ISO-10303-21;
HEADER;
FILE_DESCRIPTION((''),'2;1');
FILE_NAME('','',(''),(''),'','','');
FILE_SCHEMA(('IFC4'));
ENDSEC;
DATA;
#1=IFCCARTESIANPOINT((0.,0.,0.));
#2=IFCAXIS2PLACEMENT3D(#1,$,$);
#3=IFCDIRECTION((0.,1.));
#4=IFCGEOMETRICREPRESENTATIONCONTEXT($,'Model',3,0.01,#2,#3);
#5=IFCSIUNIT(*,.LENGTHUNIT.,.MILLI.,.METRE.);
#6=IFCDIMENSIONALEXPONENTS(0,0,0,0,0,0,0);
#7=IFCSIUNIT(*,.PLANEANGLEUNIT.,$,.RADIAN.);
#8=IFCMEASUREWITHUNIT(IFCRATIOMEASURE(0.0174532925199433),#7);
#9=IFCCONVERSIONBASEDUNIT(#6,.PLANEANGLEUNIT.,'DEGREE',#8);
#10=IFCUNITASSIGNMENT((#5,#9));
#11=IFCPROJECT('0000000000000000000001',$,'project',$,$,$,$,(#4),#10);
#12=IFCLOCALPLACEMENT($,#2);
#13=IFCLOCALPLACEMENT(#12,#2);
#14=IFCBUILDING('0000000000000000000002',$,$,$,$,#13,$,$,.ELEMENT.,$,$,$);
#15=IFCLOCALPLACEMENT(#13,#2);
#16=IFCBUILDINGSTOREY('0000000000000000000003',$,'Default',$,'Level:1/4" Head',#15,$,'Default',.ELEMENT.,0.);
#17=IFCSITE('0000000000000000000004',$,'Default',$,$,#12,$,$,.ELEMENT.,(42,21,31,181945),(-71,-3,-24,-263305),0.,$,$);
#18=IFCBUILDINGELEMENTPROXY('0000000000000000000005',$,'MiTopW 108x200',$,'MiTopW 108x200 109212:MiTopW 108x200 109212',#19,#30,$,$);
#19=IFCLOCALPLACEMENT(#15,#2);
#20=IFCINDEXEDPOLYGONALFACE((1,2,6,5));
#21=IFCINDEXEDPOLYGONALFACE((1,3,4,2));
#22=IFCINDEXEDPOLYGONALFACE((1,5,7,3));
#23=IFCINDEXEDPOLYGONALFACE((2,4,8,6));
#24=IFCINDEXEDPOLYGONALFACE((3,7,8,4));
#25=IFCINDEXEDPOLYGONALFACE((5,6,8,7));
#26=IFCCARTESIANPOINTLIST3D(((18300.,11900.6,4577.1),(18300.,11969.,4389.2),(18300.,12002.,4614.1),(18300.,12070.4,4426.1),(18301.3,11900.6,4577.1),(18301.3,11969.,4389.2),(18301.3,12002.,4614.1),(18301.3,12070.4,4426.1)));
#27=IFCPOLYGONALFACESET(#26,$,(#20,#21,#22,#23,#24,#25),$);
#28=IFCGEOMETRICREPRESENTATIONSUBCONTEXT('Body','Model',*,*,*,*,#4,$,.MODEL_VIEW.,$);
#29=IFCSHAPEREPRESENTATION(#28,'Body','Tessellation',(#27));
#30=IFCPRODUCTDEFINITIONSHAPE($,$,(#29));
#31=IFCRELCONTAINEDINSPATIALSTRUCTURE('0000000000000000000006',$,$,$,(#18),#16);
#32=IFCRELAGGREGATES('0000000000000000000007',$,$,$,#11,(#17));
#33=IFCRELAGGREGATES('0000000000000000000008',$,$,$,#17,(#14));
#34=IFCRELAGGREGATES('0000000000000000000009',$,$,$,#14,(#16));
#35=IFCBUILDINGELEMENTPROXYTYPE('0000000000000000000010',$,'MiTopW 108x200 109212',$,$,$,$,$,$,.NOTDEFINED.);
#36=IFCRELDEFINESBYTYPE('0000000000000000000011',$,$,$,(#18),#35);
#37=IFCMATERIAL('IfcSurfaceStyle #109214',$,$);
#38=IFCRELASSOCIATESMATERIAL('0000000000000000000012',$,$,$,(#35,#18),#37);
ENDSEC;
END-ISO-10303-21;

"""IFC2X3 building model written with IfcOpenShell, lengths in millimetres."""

from ifc_helpers import new_model, entity, si_unit, converted_unit, direction, frame, origin, place, context, subcontext, project, spatial, polyline, outline, extrude, source, transform, mapped, material, type_object, type_shapes, element, save


model = new_model("IFC2X3")

# Units and contexts
model_context = context("Model", 3, precision=0.01, world=origin(), true_north=direction((0.0, 1.0)))
body_context = subcontext(model_context, "Body", "Model", "MODEL_VIEW")
ifc_project = project(units=[si_unit("LENGTHUNIT", "METRE", prefix="MILLI"), converted_unit("PLANEANGLEUNIT", "DEGREE", entity("IfcRatioMeasure", 0.0174532925199433), si_unit("PLANEANGLEUNIT", "RADIAN"), dimensions=[0, 0, 0, 0, 0, 0, 0])], contexts=[model_context])

# Site, building, storey
site_placement = place(None, origin())
site = spatial("IfcSite", under=ifc_project, at=site_placement, Name="Default", CompositionType="ELEMENT", RefLatitude=(42, 21, 31, 181945), RefLongitude=(-71, -3, -24, -263305), RefElevation=0.0)
building_placement = place(site_placement, origin())
building = spatial("IfcBuilding", under=site, at=building_placement, CompositionType="ELEMENT")
storey_placement = place(building_placement, origin())
storey = spatial("IfcBuildingStorey", under=building, at=storey_placement, Name="Default", ObjectType="Level:1/4\" Head", LongName="Default", CompositionType="ELEMENT", Elevation=0.0)

# Building element proxy
ifc_material_1 = material(Name="IfcSurfaceStyle #109214")
building_element_proxy_type_1 = type_object("IfcBuildingElementProxyType", Name="MiTopW 108x200 109212", PredefinedType="NOTDEFINED", material=ifc_material_1)
shared_shape_1 = source(origin(), body_context, "Body", "SweptSolid", [
    extrude(outline(polyline([(-54.0, -100.0), (54.0, -100.0), (54.0, 100.0), (-54.0, 100.0), (-54.0, -100.0)])), frame((100.0, 54.0, 0.0), z_axis=(0.0, 0.0, 1.0), x_axis=(-0.000002, 1.0, 0.0)), (0.0, 0.0, 1.0), 1.3),
])
type_shapes(building_element_proxy_type_1, [shared_shape_1])
proxy_1_placement = place(building_placement, frame((18301.3, 12002.0, 4614.1), z_axis=(-1.0, 0.0, 0.0), x_axis=(0.0, 0.34202, -0.939693)))
element("IfcBuildingElementProxy", 1, at=proxy_1_placement, inside=storey, type_object=building_element_proxy_type_1, material=ifc_material_1, Name="MiTopW 108x200", ObjectType="MiTopW 108x200 109212:MiTopW 108x200 109212", context=body_context, shape_type="MappedRepresentation", body=[
    mapped(shared_shape_1, transform((0.0, 0.0, 0.0), scale=1.0)),
])

save(model, "model.ifc")
